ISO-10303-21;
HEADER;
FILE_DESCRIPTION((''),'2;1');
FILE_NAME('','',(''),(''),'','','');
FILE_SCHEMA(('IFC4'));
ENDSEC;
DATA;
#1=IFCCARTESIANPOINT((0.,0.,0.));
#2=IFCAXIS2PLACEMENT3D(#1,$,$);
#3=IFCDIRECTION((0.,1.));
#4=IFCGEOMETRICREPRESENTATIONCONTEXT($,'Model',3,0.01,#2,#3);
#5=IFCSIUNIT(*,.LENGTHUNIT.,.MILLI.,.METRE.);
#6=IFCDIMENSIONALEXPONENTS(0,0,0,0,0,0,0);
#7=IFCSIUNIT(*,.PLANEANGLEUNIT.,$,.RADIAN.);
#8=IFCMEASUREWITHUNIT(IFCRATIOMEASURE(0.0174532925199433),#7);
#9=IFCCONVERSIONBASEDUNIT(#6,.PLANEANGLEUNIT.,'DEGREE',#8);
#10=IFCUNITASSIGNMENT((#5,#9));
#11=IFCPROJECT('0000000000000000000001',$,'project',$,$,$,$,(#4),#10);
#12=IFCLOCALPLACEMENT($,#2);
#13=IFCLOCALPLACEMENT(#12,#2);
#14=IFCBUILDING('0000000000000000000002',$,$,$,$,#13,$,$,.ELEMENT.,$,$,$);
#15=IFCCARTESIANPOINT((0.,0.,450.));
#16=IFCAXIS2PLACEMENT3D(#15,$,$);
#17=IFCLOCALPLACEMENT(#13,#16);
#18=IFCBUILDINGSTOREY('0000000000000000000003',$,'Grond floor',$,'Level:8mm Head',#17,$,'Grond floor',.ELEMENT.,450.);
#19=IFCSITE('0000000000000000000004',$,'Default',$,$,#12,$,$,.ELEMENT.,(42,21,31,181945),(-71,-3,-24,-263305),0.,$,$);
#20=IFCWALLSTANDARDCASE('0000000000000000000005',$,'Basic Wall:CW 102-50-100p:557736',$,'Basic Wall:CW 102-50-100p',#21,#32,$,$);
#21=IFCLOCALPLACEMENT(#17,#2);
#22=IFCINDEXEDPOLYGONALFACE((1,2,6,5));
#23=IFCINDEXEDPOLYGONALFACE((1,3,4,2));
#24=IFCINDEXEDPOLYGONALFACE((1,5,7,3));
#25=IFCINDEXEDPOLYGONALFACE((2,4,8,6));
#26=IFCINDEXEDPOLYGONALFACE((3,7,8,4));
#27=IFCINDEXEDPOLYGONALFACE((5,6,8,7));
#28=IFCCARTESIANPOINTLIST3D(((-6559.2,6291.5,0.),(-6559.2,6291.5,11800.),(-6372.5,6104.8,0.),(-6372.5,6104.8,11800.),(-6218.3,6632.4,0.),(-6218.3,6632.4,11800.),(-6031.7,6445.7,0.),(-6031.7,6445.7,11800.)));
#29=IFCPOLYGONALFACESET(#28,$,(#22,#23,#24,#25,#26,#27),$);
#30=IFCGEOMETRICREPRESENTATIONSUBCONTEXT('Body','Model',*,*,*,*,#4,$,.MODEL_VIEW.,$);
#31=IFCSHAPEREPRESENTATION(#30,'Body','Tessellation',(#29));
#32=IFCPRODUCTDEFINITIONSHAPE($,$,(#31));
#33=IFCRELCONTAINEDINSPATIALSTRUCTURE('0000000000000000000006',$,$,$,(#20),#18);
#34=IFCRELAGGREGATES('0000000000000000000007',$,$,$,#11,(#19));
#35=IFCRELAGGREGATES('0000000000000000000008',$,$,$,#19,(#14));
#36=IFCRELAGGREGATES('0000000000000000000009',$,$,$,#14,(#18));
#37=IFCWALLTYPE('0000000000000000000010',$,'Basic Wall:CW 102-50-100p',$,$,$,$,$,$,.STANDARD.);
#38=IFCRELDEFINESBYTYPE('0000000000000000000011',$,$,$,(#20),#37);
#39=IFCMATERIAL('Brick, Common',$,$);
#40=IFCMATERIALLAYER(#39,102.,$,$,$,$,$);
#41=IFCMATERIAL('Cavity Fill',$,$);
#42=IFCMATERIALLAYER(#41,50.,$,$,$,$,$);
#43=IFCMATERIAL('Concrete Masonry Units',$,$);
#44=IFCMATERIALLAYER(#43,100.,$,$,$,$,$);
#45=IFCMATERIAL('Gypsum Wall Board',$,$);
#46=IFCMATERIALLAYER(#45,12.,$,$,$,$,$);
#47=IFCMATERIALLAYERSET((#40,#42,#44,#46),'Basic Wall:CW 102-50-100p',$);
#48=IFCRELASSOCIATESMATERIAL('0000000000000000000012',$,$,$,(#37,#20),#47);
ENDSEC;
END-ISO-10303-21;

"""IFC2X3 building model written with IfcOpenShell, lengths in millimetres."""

from ifc_helpers import new_model, entity, si_unit, converted_unit, direction, frame, frame_2d, origin, place, context, subcontext, project, spatial, rectangle, extrude, material, layer, layer_set, layer_usage, type_object, element, save


model = new_model("IFC2X3")

# Units and contexts
model_context = context("Model", 3, precision=0.01, world=origin(), true_north=direction((0.0, 1.0)))
body_context = subcontext(model_context, "Body", "Model", "MODEL_VIEW")
ifc_project = project(units=[si_unit("LENGTHUNIT", "METRE", prefix="MILLI"), converted_unit("PLANEANGLEUNIT", "DEGREE", entity("IfcRatioMeasure", 0.0174532925199433), si_unit("PLANEANGLEUNIT", "RADIAN"), dimensions=[0, 0, 0, 0, 0, 0, 0])], contexts=[model_context])

# Site, building, storey
site_placement = place(None, origin())
site = spatial("IfcSite", under=ifc_project, at=site_placement, Name="Default", CompositionType="ELEMENT", RefLatitude=(42, 21, 31, 181945), RefLongitude=(-71, -3, -24, -263305), RefElevation=0.0)
building_placement = place(site_placement, origin())
building = spatial("IfcBuilding", under=site, at=building_placement, CompositionType="ELEMENT")
storey_placement = place(building_placement, frame((0.0, 0.0, 450.0)))
storey = spatial("IfcBuildingStorey", under=building, at=storey_placement, Name="Grond floor", ObjectType="Level:8mm Head", LongName="Grond floor", CompositionType="ELEMENT", Elevation=450.0)

# Wall
ifc_material_1 = material(Name="Brick, Common")
ifc_layer_1 = layer(ifc_material_1, 102.0)
ifc_material_2 = material(Name="Cavity Fill")
ifc_layer_2 = layer(ifc_material_2, 50.0)
ifc_material_3 = material(Name="Concrete Masonry Units")
ifc_layer_3 = layer(ifc_material_3, 100.0)
ifc_material_4 = material(Name="Gypsum Wall Board")
ifc_layer_4 = layer(ifc_material_4, 12.0)
ifc_layer_set = layer_set([ifc_layer_1, ifc_layer_2, ifc_layer_3, ifc_layer_4], Name="Basic Wall:CW 102-50-100p")
ifc_layer_usage = layer_usage(ifc_layer_set, "AXIS2", "NEGATIVE", 132.0)
wall_type = type_object("IfcWallType", Name="Basic Wall:CW 102-50-100p", PredefinedType="STANDARD", material=ifc_layer_set)
wall_placement = place(storey_placement, frame((-6125.0, 6539.0, 0.0), z_axis=(0.0, 0.0, 1.0), x_axis=(-0.707107, -0.707107, 0.0)))
element("IfcWallStandardCase", 1, at=wall_placement, inside=storey, type_object=wall_type, material=ifc_layer_usage, Name="Basic Wall:CW 102-50-100p:557736", ObjectType="Basic Wall:CW 102-50-100p", context=body_context, shape_type="SweptSolid", body=[
    extrude(rectangle(XDim=482.0, YDim=264.0, at=frame_2d((241.0, 0.0), x_axis=(-1.0, 0.0))), origin(), (0.0, 0.0, 1.0), 11800.0),
])

save(model, "model.ifc")
